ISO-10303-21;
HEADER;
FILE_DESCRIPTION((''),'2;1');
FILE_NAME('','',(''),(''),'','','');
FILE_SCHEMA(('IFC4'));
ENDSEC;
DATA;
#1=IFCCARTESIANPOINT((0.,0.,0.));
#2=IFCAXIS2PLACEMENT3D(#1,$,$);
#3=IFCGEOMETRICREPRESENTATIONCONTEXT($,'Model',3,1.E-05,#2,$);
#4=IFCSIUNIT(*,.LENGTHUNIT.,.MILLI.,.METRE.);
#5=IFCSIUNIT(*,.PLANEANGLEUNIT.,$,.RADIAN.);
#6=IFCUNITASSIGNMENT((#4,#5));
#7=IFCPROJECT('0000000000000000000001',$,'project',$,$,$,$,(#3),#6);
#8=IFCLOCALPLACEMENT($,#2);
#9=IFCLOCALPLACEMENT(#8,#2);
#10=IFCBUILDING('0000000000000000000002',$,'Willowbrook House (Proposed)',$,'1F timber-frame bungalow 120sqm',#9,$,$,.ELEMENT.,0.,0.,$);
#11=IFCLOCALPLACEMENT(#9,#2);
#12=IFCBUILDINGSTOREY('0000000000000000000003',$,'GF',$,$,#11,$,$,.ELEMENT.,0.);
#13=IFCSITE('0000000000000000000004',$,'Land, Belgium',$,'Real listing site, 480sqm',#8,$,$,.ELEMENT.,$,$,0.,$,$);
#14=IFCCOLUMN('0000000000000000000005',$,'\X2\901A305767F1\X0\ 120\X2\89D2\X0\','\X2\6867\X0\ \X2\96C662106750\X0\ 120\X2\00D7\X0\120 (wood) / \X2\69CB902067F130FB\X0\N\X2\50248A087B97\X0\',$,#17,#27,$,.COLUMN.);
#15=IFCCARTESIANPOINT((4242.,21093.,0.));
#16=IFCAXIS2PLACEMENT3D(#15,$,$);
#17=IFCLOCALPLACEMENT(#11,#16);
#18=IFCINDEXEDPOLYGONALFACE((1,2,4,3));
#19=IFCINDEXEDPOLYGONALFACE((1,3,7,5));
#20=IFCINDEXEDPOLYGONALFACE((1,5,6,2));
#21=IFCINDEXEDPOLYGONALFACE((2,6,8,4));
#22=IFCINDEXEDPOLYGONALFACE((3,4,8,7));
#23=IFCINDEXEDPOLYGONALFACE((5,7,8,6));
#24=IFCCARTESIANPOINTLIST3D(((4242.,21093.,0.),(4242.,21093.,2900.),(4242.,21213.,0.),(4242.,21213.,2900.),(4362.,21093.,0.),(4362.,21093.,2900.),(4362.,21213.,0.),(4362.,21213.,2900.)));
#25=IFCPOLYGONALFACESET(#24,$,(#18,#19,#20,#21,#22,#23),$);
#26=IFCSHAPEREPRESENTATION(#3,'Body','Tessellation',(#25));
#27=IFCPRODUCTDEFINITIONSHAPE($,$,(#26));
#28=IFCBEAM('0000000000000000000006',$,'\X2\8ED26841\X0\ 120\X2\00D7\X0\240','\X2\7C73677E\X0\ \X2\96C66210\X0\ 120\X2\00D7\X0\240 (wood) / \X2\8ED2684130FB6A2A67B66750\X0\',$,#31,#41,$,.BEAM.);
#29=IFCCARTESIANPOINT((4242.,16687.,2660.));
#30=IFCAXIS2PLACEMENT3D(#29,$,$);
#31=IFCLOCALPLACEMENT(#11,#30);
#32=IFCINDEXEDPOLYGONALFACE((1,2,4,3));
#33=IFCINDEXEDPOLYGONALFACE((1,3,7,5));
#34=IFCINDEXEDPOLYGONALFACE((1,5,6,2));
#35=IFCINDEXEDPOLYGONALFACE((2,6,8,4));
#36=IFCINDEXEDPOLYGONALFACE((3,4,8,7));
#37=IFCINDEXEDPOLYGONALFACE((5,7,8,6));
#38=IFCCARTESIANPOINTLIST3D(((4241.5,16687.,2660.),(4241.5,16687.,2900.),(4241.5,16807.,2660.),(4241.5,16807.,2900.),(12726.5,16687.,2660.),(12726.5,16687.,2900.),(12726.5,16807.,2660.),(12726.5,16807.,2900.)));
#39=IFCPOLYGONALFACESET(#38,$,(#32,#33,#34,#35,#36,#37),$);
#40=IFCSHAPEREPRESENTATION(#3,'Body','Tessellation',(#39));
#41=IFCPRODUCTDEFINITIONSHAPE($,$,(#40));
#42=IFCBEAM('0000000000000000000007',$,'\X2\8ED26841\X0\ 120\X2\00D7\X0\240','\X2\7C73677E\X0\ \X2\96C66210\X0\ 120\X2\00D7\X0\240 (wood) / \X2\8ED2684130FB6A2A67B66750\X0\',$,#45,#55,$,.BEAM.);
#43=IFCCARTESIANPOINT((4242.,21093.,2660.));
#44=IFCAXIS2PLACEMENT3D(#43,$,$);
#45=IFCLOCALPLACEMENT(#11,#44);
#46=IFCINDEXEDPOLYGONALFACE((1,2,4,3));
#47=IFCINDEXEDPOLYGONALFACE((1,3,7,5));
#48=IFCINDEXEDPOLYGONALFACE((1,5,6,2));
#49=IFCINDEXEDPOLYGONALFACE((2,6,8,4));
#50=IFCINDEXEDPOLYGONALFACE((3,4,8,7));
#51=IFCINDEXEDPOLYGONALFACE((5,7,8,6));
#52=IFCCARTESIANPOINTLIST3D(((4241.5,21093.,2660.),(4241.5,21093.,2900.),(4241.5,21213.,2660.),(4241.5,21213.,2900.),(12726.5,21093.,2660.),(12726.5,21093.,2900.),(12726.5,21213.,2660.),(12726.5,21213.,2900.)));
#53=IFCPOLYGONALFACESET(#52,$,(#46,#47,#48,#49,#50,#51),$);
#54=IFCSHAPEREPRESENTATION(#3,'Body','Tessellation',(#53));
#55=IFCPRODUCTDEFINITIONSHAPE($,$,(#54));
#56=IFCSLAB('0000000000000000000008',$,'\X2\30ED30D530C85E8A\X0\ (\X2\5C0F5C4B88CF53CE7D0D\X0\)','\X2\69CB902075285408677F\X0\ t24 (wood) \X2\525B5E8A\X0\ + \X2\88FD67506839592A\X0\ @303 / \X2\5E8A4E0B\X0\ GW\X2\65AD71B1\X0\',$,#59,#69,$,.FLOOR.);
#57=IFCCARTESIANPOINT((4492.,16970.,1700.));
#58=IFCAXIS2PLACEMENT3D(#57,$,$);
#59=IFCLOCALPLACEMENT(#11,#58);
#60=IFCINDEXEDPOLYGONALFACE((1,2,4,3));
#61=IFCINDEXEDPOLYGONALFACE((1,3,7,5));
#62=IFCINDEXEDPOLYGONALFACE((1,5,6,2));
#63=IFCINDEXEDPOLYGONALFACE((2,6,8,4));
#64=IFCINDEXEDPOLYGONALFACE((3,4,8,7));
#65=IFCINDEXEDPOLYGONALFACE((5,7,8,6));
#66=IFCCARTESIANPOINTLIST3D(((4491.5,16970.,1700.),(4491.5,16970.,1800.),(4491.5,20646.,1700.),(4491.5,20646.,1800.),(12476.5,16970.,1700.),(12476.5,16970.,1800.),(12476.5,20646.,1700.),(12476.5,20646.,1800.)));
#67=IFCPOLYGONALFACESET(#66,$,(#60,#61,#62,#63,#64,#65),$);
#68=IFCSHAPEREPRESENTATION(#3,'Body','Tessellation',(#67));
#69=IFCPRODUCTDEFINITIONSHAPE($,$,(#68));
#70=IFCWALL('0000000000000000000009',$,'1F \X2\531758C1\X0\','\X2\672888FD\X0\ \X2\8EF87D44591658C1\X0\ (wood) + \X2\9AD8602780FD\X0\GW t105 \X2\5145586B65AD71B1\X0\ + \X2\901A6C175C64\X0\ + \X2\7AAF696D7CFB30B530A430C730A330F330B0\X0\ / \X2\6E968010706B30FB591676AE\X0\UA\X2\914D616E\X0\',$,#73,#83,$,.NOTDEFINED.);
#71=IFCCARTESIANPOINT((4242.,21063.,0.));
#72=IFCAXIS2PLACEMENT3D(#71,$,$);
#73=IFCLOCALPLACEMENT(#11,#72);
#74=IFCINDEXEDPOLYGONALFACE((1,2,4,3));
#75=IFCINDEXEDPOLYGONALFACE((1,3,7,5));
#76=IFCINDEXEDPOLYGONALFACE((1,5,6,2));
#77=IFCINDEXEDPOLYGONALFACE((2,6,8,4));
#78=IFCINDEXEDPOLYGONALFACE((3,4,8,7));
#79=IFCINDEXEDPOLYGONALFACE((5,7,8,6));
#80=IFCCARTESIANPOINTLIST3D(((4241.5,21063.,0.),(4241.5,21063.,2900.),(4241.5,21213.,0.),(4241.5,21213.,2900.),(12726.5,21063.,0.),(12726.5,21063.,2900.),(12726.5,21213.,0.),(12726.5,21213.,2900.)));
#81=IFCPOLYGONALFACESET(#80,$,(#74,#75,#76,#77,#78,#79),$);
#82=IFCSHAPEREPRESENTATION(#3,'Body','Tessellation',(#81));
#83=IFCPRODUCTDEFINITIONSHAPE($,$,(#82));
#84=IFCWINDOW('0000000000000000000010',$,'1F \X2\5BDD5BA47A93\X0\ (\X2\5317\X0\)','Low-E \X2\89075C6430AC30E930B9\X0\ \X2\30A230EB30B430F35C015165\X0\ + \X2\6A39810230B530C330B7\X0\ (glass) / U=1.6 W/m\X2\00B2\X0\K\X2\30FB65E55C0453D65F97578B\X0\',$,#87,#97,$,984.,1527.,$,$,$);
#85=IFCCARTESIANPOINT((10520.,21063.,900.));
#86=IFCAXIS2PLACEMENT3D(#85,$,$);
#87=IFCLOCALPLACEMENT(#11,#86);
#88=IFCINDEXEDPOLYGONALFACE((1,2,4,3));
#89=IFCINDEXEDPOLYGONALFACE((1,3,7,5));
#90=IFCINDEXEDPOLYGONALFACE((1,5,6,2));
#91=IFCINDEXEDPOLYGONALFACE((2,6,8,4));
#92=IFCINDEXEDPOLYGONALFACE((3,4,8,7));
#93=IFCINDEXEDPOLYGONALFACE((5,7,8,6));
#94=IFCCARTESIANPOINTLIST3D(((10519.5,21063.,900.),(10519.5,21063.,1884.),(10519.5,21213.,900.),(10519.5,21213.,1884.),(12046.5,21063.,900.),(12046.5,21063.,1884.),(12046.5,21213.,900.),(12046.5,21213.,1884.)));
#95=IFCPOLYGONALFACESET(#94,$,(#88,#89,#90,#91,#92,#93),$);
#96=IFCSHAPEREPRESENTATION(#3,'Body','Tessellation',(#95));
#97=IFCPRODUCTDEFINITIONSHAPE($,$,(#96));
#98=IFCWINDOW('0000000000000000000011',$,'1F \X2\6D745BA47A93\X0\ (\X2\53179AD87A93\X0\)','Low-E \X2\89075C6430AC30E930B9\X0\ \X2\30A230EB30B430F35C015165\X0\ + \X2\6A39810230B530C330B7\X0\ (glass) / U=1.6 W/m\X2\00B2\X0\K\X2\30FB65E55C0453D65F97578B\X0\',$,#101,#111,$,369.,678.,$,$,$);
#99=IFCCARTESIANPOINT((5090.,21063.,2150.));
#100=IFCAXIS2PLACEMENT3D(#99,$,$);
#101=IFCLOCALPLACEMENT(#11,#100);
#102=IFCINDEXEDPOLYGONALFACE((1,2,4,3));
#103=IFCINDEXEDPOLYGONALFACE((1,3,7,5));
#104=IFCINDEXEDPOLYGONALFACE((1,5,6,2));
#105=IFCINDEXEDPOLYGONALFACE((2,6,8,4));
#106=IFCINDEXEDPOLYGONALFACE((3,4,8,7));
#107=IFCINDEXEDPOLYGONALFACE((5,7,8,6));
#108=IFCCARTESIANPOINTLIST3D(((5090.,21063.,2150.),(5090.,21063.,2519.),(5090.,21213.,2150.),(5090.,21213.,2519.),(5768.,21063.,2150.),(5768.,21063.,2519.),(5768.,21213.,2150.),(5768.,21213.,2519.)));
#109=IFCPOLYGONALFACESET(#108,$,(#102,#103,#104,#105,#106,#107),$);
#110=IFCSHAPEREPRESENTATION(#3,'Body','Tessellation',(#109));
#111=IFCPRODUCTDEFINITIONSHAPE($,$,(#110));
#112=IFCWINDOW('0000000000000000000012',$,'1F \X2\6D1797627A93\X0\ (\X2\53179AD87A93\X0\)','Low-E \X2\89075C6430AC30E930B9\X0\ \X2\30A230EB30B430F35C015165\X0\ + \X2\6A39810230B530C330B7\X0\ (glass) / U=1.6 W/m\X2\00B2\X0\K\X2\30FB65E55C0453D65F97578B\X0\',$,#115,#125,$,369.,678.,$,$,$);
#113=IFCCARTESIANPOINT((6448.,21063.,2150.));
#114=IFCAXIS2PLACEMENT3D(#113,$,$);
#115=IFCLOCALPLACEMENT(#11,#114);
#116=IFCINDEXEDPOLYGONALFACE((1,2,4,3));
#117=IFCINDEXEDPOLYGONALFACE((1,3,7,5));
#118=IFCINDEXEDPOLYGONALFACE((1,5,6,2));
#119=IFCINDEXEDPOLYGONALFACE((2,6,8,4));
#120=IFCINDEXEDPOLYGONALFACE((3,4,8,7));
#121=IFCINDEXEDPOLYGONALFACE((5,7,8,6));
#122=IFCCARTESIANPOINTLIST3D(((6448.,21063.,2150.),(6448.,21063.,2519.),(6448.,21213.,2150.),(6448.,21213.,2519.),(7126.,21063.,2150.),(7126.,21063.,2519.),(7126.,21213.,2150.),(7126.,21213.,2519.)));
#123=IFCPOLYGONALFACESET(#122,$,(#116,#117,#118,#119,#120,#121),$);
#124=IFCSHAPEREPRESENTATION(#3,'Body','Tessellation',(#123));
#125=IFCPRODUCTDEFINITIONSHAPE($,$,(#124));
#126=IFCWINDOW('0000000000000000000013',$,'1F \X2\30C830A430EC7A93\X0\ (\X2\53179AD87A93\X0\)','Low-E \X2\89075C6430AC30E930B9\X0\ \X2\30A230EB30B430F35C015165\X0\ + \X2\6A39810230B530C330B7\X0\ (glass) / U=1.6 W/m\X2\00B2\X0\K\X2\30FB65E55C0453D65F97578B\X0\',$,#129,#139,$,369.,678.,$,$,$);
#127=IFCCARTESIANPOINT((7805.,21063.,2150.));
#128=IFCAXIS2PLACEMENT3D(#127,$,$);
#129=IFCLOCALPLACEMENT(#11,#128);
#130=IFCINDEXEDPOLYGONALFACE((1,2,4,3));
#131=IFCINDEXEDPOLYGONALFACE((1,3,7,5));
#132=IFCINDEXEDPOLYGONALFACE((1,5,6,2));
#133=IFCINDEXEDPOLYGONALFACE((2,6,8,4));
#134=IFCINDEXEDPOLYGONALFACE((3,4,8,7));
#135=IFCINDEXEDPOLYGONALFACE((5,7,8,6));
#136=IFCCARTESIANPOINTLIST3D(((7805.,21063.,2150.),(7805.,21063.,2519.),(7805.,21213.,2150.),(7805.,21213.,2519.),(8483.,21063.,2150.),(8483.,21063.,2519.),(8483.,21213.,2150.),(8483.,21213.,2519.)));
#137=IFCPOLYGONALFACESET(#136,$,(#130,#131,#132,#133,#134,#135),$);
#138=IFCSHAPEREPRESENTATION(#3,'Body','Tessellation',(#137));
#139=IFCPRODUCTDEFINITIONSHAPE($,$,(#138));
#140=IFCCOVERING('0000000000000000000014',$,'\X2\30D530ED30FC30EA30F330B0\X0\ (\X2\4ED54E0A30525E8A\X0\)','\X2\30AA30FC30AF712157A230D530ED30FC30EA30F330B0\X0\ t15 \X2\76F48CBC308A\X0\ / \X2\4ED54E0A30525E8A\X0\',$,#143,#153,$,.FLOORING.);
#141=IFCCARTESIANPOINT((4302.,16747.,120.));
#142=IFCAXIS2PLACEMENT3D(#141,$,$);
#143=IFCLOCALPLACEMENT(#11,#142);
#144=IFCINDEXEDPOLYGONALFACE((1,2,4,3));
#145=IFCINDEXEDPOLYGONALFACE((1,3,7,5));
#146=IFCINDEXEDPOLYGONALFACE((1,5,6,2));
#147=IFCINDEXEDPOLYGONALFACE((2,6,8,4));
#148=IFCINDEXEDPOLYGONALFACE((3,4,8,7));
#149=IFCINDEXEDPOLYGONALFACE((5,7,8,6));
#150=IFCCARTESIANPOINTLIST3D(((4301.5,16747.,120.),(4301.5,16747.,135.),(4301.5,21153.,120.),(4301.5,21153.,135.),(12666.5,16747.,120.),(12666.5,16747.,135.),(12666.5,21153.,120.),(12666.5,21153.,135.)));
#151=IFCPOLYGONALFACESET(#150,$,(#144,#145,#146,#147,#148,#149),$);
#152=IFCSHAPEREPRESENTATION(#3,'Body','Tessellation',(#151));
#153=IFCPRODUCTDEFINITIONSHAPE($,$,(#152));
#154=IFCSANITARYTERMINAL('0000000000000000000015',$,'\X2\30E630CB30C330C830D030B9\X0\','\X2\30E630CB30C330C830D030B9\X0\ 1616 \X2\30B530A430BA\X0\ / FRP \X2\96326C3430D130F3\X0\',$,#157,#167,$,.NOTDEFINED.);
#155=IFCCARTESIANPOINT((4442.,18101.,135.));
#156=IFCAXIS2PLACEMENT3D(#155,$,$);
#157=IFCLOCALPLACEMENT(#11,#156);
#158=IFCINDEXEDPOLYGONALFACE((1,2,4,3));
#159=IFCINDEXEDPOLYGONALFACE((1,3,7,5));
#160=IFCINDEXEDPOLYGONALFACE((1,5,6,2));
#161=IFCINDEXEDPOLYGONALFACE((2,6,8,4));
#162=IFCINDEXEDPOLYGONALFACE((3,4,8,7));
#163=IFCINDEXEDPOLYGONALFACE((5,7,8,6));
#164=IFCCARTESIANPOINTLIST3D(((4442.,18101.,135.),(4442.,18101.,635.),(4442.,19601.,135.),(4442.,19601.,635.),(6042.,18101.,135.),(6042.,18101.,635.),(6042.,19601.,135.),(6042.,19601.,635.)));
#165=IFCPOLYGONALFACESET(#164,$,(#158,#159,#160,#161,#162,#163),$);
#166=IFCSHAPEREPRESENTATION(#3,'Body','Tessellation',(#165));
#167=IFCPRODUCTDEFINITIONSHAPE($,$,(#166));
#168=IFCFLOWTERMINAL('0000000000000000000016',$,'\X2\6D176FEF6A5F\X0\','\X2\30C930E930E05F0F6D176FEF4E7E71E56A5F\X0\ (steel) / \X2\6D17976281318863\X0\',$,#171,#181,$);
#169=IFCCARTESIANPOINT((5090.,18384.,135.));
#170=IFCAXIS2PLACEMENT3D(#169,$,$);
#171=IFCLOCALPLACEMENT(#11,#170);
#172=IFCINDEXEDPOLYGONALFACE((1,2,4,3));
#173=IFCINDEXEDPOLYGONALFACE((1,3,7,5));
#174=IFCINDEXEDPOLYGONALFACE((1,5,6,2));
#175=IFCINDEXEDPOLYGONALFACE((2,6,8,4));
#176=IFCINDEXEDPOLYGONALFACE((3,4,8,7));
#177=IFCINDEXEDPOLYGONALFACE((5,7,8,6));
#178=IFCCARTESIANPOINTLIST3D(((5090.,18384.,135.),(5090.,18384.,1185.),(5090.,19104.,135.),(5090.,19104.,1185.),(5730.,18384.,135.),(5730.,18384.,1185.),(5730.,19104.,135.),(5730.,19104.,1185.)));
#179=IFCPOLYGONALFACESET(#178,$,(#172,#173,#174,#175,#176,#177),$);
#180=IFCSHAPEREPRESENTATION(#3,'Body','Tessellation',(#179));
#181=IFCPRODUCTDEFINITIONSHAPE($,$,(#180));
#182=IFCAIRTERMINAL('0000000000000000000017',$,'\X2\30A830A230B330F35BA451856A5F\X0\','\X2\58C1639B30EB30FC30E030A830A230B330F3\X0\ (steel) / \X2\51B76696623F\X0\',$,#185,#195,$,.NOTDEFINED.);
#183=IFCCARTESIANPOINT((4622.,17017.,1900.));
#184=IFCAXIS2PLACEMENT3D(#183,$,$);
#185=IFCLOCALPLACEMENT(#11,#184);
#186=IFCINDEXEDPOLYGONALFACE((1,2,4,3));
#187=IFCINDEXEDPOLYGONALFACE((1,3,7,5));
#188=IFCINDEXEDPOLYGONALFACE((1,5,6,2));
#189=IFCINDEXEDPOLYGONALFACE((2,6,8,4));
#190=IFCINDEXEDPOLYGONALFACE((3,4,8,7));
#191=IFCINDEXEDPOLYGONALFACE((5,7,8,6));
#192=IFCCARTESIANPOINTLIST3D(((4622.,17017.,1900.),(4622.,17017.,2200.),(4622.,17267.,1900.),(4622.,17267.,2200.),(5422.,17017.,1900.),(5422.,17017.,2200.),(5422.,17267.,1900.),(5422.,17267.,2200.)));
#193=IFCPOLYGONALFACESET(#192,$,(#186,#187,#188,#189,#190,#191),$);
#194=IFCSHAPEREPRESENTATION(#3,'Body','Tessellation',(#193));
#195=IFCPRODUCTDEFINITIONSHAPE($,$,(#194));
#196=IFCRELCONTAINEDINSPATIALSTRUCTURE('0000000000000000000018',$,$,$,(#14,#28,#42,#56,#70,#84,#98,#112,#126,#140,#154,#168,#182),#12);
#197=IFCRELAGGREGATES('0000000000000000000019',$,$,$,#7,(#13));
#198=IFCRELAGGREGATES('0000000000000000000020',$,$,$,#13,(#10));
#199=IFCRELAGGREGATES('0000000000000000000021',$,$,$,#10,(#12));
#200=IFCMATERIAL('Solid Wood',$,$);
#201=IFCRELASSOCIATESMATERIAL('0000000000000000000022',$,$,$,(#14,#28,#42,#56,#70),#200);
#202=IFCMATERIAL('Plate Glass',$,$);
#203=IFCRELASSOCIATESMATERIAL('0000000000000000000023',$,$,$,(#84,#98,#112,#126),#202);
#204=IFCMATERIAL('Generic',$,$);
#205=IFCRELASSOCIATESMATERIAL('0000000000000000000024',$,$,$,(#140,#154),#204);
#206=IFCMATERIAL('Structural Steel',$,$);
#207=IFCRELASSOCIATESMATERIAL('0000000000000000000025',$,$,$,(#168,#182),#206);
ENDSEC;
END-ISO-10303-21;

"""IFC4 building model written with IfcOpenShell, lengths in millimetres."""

from ifc_helpers import new_model, si_unit, frame, frame_2d, origin, place, context, project, spatial, rectangle, extrude, material, element, fill, save


model = new_model("IFC4")

# Units and contexts
model_context = context("Model", 3, precision=1e-05, world=origin())
ifc_project = project(units=[si_unit("LENGTHUNIT", "METRE", prefix="MILLI"), si_unit("PLANEANGLEUNIT", "RADIAN")], contexts=[model_context])

# Site, building, storey
site_placement = place(None, origin())
site = spatial("IfcSite", under=ifc_project, at=site_placement, Name="Land, Belgium", ObjectType="Real listing site, 480sqm", CompositionType="ELEMENT", RefElevation=0.0)
building_placement = place(site_placement, origin())
building = spatial("IfcBuilding", under=site, at=building_placement, Name="Willowbrook House (Proposed)", ObjectType="1F timber-frame bungalow 120sqm", CompositionType="ELEMENT", ElevationOfRefHeight=0.0, ElevationOfTerrain=0.0)
storey_placement = place(building_placement, origin())
storey = spatial("IfcBuildingStorey", under=building, at=storey_placement, Name="GF", CompositionType="ELEMENT", Elevation=0.0)

# Column
ifc_material_1 = material(Name="Solid Wood")
column_1_placement = place(storey_placement, frame((4242.0, 21093.0, 0.0)))
element("IfcColumn", 1, at=column_1_placement, inside=storey, material=ifc_material_1, Name="通し柱 120角", Description="桧 集成材 120×120 (wood) / 構造柱・N値計算", PredefinedType="COLUMN", context=model_context, shape_type="SweptSolid", body=[
    extrude(rectangle(XDim=120.0, YDim=120.0, at=frame_2d((60.0, 60.0))), frame((4242.0, 21093.0, 0.0)), (0.0, 0.0, 1.0), 2900.0),
])

# Beams
beam_1_placement = place(storey_placement, frame((4242.0, 16687.0, 2660.0)))
element("IfcBeam", 2, at=beam_1_placement, inside=storey, material=ifc_material_1, Name="軒桁 120×240", Description="米松 集成 120×240 (wood) / 軒桁・横架材", PredefinedType="BEAM", context=model_context, shape_type="SweptSolid", body=[
    extrude(rectangle(XDim=8485.0, YDim=120.0, at=frame_2d((4242.0, 60.0))), frame((4242.0, 16687.0, 2660.0)), (0.0, 0.0, 1.0), 240.0),
])
beam_2_placement = place(storey_placement, frame((4242.0, 21093.0, 2660.0)))
element("IfcBeam", 3, at=beam_2_placement, inside=storey, material=ifc_material_1, Name="軒桁 120×240", Description="米松 集成 120×240 (wood) / 軒桁・横架材", PredefinedType="BEAM", context=model_context, shape_type="SweptSolid", body=[
    extrude(rectangle(XDim=8485.0, YDim=120.0, at=frame_2d((4242.0, 60.0))), frame((4242.0, 21093.0, 2660.0)), (0.0, 0.0, 1.0), 240.0),
])

# Slab
slab_placement = place(storey_placement, frame((4492.0, 16970.0, 1700.0)))
element("IfcSlab", 4, at=slab_placement, inside=storey, material=ifc_material_1, Name="ロフト床 (小屋裏収納)", Description="構造用合板 t24 (wood) 剛床 + 製材根太 @303 / 床下 GW断熱", PredefinedType="FLOOR", context=model_context, shape_type="SweptSolid", body=[
    extrude(rectangle(XDim=7985.0, YDim=3676.0, at=frame_2d((3992.0, 1838.0))), frame((4492.0, 16970.0, 1700.0)), (0.0, 0.0, 1.0), 100.0),
])

# Wall, openings, windows
wall_1_placement = place(storey_placement, frame((4242.0, 21063.0, 0.0)))
wall_1 = element("IfcWall", 5, at=wall_1_placement, inside=storey, material=ifc_material_1, Name="1F 北壁", Description="木製 軸組外壁 (wood) + 高性能GW t105 充填断熱 + 通気層 + 窯業系サイディング / 準耐火・外皮UA配慮", PredefinedType="NOTDEFINED", context=model_context, shape_type="SweptSolid", body=[
    extrude(rectangle(XDim=8485.0, YDim=150.0, at=frame_2d((4242.0, 75.0))), frame((4242.0, 21063.0, 0.0)), (0.0, 0.0, 1.0), 2900.0),
])
opening_1_placement = place(storey_placement, frame((10520.0, 21063.0, 900.0)))
opening_1 = element("IfcOpeningElement", 6, at=opening_1_placement, cuts=wall_1, PredefinedType="NOTDEFINED", context=model_context, shape_type="SweptSolid", body=[
    extrude(rectangle(XDim=1527.0, YDim=150.0, at=frame_2d((763.0, 75.0))), frame((10520.0, 21063.0, 900.0)), (0.0, 0.0, 1.0), 984.0),
])
opening_2_placement = place(storey_placement, frame((5090.0, 21063.0, 2150.0)))
opening_2 = element("IfcOpeningElement", 7, at=opening_2_placement, cuts=wall_1, PredefinedType="NOTDEFINED", context=model_context, shape_type="SweptSolid", body=[
    extrude(rectangle(XDim=678.0, YDim=150.0, at=frame_2d((339.0, 75.0))), frame((5090.0, 21063.0, 2150.0)), (0.0, 0.0, 1.0), 369.0),
])
opening_3_placement = place(storey_placement, frame((6448.0, 21063.0, 2150.0)))
opening_3 = element("IfcOpeningElement", 8, at=opening_3_placement, cuts=wall_1, PredefinedType="NOTDEFINED", context=model_context, shape_type="SweptSolid", body=[
    extrude(rectangle(XDim=678.0, YDim=150.0, at=frame_2d((339.0, 75.0))), frame((6448.0, 21063.0, 2150.0)), (0.0, 0.0, 1.0), 369.0),
])
opening_4_placement = place(storey_placement, frame((7805.0, 21063.0, 2150.0)))
opening_4 = element("IfcOpeningElement", 9, at=opening_4_placement, cuts=wall_1, PredefinedType="NOTDEFINED", context=model_context, shape_type="SweptSolid", body=[
    extrude(rectangle(XDim=678.0, YDim=150.0, at=frame_2d((339.0, 75.0))), frame((7805.0, 21063.0, 2150.0)), (0.0, 0.0, 1.0), 369.0),
])
ifc_material_2 = material(Name="Plate Glass")
window_1_placement = place(storey_placement, frame((10520.0, 21063.0, 900.0)))
window_1 = element("IfcWindow", 10, at=window_1_placement, inside=storey, material=ifc_material_2, Name="1F 寝室窓 (北)", Description="Low-E 複層ガラス アルゴン封入 + 樹脂サッシ (glass) / U=1.6 W/m²K・日射取得型", OverallHeight=984.0, OverallWidth=1527.0, context=model_context, shape_type="SweptSolid", body=[
    extrude(rectangle(XDim=1527.0, YDim=150.0, at=frame_2d((763.0, 75.0))), frame((10520.0, 21063.0, 900.0)), (0.0, 0.0, 1.0), 984.0),
])
fill(opening_1, window_1)
window_2_placement = place(storey_placement, frame((5090.0, 21063.0, 2150.0)))
window_2 = element("IfcWindow", 11, at=window_2_placement, inside=storey, material=ifc_material_2, Name="1F 浴室窓 (北高窓)", Description="Low-E 複層ガラス アルゴン封入 + 樹脂サッシ (glass) / U=1.6 W/m²K・日射取得型", OverallHeight=369.0, OverallWidth=678.0, context=model_context, shape_type="SweptSolid", body=[
    extrude(rectangle(XDim=678.0, YDim=150.0, at=frame_2d((339.0, 75.0))), frame((5090.0, 21063.0, 2150.0)), (0.0, 0.0, 1.0), 369.0),
])
fill(opening_2, window_2)
window_3_placement = place(storey_placement, frame((6448.0, 21063.0, 2150.0)))
window_3 = element("IfcWindow", 12, at=window_3_placement, inside=storey, material=ifc_material_2, Name="1F 洗面窓 (北高窓)", Description="Low-E 複層ガラス アルゴン封入 + 樹脂サッシ (glass) / U=1.6 W/m²K・日射取得型", OverallHeight=369.0, OverallWidth=678.0, context=model_context, shape_type="SweptSolid", body=[
    extrude(rectangle(XDim=678.0, YDim=150.0, at=frame_2d((339.0, 75.0))), frame((6448.0, 21063.0, 2150.0)), (0.0, 0.0, 1.0), 369.0),
])
fill(opening_3, window_3)
window_4_placement = place(storey_placement, frame((7805.0, 21063.0, 2150.0)))
window_4 = element("IfcWindow", 13, at=window_4_placement, inside=storey, material=ifc_material_2, Name="1F トイレ窓 (北高窓)", Description="Low-E 複層ガラス アルゴン封入 + 樹脂サッシ (glass) / U=1.6 W/m²K・日射取得型", OverallHeight=369.0, OverallWidth=678.0, context=model_context, shape_type="SweptSolid", body=[
    extrude(rectangle(XDim=678.0, YDim=150.0, at=frame_2d((339.0, 75.0))), frame((7805.0, 21063.0, 2150.0)), (0.0, 0.0, 1.0), 369.0),
])
fill(opening_4, window_4)

# Covering
ifc_material_3 = material(Name="Generic")
covering_placement = place(storey_placement, frame((4302.0, 16747.0, 120.0)))
element("IfcCovering", 14, at=covering_placement, inside=storey, material=ifc_material_3, Name="フローリング (仕上げ床)", Description="オーク無垢フローリング t15 直貼り / 仕上げ床", PredefinedType="FLOORING", context=model_context, shape_type="SweptSolid", body=[
    extrude(rectangle(XDim=8365.0, YDim=4406.0, at=frame_2d((4182.0, 2203.0))), frame((4302.0, 16747.0, 120.0)), (0.0, 0.0, 1.0), 15.0),
])

# Sanitary terminal
sanitary_terminal_placement = place(storey_placement, frame((4442.0, 18101.0, 135.0)))
element("IfcSanitaryTerminal", 15, at=sanitary_terminal_placement, inside=storey, material=ifc_material_3, Name="ユニットバス", Description="ユニットバス 1616 サイズ / FRP 防水パン", PredefinedType="NOTDEFINED", context=model_context, shape_type="SweptSolid", body=[
    extrude(rectangle(XDim=1600.0, YDim=1500.0, at=frame_2d((800.0, 750.0))), frame((4442.0, 18101.0, 135.0)), (0.0, 0.0, 1.0), 500.0),
])

# Flow terminal
ifc_material_4 = material(Name="Structural Steel")
flow_terminal_placement = place(storey_placement, frame((5090.0, 18384.0, 135.0)))
element("IfcFlowTerminal", 16, at=flow_terminal_placement, inside=storey, material=ifc_material_4, Name="洗濯機", Description="ドラム式洗濯乾燥機 (steel) / 洗面脱衣", context=model_context, shape_type="SweptSolid", body=[
    extrude(rectangle(XDim=640.0, YDim=720.0, at=frame_2d((320.0, 360.0))), frame((5090.0, 18384.0, 135.0)), (0.0, 0.0, 1.0), 1050.0),
])

# Air terminal
air_terminal_placement = place(storey_placement, frame((4622.0, 17017.0, 1900.0)))
element("IfcAirTerminal", 17, at=air_terminal_placement, inside=storey, material=ifc_material_4, Name="エアコン室内機", Description="壁掛ルームエアコン (steel) / 冷暖房", PredefinedType="NOTDEFINED", context=model_context, shape_type="SweptSolid", body=[
    extrude(rectangle(XDim=800.0, YDim=250.0, at=frame_2d((400.0, 125.0))), frame((4622.0, 17017.0, 1900.0)), (0.0, 0.0, 1.0), 300.0),
])

save(model, "model.ifc")
